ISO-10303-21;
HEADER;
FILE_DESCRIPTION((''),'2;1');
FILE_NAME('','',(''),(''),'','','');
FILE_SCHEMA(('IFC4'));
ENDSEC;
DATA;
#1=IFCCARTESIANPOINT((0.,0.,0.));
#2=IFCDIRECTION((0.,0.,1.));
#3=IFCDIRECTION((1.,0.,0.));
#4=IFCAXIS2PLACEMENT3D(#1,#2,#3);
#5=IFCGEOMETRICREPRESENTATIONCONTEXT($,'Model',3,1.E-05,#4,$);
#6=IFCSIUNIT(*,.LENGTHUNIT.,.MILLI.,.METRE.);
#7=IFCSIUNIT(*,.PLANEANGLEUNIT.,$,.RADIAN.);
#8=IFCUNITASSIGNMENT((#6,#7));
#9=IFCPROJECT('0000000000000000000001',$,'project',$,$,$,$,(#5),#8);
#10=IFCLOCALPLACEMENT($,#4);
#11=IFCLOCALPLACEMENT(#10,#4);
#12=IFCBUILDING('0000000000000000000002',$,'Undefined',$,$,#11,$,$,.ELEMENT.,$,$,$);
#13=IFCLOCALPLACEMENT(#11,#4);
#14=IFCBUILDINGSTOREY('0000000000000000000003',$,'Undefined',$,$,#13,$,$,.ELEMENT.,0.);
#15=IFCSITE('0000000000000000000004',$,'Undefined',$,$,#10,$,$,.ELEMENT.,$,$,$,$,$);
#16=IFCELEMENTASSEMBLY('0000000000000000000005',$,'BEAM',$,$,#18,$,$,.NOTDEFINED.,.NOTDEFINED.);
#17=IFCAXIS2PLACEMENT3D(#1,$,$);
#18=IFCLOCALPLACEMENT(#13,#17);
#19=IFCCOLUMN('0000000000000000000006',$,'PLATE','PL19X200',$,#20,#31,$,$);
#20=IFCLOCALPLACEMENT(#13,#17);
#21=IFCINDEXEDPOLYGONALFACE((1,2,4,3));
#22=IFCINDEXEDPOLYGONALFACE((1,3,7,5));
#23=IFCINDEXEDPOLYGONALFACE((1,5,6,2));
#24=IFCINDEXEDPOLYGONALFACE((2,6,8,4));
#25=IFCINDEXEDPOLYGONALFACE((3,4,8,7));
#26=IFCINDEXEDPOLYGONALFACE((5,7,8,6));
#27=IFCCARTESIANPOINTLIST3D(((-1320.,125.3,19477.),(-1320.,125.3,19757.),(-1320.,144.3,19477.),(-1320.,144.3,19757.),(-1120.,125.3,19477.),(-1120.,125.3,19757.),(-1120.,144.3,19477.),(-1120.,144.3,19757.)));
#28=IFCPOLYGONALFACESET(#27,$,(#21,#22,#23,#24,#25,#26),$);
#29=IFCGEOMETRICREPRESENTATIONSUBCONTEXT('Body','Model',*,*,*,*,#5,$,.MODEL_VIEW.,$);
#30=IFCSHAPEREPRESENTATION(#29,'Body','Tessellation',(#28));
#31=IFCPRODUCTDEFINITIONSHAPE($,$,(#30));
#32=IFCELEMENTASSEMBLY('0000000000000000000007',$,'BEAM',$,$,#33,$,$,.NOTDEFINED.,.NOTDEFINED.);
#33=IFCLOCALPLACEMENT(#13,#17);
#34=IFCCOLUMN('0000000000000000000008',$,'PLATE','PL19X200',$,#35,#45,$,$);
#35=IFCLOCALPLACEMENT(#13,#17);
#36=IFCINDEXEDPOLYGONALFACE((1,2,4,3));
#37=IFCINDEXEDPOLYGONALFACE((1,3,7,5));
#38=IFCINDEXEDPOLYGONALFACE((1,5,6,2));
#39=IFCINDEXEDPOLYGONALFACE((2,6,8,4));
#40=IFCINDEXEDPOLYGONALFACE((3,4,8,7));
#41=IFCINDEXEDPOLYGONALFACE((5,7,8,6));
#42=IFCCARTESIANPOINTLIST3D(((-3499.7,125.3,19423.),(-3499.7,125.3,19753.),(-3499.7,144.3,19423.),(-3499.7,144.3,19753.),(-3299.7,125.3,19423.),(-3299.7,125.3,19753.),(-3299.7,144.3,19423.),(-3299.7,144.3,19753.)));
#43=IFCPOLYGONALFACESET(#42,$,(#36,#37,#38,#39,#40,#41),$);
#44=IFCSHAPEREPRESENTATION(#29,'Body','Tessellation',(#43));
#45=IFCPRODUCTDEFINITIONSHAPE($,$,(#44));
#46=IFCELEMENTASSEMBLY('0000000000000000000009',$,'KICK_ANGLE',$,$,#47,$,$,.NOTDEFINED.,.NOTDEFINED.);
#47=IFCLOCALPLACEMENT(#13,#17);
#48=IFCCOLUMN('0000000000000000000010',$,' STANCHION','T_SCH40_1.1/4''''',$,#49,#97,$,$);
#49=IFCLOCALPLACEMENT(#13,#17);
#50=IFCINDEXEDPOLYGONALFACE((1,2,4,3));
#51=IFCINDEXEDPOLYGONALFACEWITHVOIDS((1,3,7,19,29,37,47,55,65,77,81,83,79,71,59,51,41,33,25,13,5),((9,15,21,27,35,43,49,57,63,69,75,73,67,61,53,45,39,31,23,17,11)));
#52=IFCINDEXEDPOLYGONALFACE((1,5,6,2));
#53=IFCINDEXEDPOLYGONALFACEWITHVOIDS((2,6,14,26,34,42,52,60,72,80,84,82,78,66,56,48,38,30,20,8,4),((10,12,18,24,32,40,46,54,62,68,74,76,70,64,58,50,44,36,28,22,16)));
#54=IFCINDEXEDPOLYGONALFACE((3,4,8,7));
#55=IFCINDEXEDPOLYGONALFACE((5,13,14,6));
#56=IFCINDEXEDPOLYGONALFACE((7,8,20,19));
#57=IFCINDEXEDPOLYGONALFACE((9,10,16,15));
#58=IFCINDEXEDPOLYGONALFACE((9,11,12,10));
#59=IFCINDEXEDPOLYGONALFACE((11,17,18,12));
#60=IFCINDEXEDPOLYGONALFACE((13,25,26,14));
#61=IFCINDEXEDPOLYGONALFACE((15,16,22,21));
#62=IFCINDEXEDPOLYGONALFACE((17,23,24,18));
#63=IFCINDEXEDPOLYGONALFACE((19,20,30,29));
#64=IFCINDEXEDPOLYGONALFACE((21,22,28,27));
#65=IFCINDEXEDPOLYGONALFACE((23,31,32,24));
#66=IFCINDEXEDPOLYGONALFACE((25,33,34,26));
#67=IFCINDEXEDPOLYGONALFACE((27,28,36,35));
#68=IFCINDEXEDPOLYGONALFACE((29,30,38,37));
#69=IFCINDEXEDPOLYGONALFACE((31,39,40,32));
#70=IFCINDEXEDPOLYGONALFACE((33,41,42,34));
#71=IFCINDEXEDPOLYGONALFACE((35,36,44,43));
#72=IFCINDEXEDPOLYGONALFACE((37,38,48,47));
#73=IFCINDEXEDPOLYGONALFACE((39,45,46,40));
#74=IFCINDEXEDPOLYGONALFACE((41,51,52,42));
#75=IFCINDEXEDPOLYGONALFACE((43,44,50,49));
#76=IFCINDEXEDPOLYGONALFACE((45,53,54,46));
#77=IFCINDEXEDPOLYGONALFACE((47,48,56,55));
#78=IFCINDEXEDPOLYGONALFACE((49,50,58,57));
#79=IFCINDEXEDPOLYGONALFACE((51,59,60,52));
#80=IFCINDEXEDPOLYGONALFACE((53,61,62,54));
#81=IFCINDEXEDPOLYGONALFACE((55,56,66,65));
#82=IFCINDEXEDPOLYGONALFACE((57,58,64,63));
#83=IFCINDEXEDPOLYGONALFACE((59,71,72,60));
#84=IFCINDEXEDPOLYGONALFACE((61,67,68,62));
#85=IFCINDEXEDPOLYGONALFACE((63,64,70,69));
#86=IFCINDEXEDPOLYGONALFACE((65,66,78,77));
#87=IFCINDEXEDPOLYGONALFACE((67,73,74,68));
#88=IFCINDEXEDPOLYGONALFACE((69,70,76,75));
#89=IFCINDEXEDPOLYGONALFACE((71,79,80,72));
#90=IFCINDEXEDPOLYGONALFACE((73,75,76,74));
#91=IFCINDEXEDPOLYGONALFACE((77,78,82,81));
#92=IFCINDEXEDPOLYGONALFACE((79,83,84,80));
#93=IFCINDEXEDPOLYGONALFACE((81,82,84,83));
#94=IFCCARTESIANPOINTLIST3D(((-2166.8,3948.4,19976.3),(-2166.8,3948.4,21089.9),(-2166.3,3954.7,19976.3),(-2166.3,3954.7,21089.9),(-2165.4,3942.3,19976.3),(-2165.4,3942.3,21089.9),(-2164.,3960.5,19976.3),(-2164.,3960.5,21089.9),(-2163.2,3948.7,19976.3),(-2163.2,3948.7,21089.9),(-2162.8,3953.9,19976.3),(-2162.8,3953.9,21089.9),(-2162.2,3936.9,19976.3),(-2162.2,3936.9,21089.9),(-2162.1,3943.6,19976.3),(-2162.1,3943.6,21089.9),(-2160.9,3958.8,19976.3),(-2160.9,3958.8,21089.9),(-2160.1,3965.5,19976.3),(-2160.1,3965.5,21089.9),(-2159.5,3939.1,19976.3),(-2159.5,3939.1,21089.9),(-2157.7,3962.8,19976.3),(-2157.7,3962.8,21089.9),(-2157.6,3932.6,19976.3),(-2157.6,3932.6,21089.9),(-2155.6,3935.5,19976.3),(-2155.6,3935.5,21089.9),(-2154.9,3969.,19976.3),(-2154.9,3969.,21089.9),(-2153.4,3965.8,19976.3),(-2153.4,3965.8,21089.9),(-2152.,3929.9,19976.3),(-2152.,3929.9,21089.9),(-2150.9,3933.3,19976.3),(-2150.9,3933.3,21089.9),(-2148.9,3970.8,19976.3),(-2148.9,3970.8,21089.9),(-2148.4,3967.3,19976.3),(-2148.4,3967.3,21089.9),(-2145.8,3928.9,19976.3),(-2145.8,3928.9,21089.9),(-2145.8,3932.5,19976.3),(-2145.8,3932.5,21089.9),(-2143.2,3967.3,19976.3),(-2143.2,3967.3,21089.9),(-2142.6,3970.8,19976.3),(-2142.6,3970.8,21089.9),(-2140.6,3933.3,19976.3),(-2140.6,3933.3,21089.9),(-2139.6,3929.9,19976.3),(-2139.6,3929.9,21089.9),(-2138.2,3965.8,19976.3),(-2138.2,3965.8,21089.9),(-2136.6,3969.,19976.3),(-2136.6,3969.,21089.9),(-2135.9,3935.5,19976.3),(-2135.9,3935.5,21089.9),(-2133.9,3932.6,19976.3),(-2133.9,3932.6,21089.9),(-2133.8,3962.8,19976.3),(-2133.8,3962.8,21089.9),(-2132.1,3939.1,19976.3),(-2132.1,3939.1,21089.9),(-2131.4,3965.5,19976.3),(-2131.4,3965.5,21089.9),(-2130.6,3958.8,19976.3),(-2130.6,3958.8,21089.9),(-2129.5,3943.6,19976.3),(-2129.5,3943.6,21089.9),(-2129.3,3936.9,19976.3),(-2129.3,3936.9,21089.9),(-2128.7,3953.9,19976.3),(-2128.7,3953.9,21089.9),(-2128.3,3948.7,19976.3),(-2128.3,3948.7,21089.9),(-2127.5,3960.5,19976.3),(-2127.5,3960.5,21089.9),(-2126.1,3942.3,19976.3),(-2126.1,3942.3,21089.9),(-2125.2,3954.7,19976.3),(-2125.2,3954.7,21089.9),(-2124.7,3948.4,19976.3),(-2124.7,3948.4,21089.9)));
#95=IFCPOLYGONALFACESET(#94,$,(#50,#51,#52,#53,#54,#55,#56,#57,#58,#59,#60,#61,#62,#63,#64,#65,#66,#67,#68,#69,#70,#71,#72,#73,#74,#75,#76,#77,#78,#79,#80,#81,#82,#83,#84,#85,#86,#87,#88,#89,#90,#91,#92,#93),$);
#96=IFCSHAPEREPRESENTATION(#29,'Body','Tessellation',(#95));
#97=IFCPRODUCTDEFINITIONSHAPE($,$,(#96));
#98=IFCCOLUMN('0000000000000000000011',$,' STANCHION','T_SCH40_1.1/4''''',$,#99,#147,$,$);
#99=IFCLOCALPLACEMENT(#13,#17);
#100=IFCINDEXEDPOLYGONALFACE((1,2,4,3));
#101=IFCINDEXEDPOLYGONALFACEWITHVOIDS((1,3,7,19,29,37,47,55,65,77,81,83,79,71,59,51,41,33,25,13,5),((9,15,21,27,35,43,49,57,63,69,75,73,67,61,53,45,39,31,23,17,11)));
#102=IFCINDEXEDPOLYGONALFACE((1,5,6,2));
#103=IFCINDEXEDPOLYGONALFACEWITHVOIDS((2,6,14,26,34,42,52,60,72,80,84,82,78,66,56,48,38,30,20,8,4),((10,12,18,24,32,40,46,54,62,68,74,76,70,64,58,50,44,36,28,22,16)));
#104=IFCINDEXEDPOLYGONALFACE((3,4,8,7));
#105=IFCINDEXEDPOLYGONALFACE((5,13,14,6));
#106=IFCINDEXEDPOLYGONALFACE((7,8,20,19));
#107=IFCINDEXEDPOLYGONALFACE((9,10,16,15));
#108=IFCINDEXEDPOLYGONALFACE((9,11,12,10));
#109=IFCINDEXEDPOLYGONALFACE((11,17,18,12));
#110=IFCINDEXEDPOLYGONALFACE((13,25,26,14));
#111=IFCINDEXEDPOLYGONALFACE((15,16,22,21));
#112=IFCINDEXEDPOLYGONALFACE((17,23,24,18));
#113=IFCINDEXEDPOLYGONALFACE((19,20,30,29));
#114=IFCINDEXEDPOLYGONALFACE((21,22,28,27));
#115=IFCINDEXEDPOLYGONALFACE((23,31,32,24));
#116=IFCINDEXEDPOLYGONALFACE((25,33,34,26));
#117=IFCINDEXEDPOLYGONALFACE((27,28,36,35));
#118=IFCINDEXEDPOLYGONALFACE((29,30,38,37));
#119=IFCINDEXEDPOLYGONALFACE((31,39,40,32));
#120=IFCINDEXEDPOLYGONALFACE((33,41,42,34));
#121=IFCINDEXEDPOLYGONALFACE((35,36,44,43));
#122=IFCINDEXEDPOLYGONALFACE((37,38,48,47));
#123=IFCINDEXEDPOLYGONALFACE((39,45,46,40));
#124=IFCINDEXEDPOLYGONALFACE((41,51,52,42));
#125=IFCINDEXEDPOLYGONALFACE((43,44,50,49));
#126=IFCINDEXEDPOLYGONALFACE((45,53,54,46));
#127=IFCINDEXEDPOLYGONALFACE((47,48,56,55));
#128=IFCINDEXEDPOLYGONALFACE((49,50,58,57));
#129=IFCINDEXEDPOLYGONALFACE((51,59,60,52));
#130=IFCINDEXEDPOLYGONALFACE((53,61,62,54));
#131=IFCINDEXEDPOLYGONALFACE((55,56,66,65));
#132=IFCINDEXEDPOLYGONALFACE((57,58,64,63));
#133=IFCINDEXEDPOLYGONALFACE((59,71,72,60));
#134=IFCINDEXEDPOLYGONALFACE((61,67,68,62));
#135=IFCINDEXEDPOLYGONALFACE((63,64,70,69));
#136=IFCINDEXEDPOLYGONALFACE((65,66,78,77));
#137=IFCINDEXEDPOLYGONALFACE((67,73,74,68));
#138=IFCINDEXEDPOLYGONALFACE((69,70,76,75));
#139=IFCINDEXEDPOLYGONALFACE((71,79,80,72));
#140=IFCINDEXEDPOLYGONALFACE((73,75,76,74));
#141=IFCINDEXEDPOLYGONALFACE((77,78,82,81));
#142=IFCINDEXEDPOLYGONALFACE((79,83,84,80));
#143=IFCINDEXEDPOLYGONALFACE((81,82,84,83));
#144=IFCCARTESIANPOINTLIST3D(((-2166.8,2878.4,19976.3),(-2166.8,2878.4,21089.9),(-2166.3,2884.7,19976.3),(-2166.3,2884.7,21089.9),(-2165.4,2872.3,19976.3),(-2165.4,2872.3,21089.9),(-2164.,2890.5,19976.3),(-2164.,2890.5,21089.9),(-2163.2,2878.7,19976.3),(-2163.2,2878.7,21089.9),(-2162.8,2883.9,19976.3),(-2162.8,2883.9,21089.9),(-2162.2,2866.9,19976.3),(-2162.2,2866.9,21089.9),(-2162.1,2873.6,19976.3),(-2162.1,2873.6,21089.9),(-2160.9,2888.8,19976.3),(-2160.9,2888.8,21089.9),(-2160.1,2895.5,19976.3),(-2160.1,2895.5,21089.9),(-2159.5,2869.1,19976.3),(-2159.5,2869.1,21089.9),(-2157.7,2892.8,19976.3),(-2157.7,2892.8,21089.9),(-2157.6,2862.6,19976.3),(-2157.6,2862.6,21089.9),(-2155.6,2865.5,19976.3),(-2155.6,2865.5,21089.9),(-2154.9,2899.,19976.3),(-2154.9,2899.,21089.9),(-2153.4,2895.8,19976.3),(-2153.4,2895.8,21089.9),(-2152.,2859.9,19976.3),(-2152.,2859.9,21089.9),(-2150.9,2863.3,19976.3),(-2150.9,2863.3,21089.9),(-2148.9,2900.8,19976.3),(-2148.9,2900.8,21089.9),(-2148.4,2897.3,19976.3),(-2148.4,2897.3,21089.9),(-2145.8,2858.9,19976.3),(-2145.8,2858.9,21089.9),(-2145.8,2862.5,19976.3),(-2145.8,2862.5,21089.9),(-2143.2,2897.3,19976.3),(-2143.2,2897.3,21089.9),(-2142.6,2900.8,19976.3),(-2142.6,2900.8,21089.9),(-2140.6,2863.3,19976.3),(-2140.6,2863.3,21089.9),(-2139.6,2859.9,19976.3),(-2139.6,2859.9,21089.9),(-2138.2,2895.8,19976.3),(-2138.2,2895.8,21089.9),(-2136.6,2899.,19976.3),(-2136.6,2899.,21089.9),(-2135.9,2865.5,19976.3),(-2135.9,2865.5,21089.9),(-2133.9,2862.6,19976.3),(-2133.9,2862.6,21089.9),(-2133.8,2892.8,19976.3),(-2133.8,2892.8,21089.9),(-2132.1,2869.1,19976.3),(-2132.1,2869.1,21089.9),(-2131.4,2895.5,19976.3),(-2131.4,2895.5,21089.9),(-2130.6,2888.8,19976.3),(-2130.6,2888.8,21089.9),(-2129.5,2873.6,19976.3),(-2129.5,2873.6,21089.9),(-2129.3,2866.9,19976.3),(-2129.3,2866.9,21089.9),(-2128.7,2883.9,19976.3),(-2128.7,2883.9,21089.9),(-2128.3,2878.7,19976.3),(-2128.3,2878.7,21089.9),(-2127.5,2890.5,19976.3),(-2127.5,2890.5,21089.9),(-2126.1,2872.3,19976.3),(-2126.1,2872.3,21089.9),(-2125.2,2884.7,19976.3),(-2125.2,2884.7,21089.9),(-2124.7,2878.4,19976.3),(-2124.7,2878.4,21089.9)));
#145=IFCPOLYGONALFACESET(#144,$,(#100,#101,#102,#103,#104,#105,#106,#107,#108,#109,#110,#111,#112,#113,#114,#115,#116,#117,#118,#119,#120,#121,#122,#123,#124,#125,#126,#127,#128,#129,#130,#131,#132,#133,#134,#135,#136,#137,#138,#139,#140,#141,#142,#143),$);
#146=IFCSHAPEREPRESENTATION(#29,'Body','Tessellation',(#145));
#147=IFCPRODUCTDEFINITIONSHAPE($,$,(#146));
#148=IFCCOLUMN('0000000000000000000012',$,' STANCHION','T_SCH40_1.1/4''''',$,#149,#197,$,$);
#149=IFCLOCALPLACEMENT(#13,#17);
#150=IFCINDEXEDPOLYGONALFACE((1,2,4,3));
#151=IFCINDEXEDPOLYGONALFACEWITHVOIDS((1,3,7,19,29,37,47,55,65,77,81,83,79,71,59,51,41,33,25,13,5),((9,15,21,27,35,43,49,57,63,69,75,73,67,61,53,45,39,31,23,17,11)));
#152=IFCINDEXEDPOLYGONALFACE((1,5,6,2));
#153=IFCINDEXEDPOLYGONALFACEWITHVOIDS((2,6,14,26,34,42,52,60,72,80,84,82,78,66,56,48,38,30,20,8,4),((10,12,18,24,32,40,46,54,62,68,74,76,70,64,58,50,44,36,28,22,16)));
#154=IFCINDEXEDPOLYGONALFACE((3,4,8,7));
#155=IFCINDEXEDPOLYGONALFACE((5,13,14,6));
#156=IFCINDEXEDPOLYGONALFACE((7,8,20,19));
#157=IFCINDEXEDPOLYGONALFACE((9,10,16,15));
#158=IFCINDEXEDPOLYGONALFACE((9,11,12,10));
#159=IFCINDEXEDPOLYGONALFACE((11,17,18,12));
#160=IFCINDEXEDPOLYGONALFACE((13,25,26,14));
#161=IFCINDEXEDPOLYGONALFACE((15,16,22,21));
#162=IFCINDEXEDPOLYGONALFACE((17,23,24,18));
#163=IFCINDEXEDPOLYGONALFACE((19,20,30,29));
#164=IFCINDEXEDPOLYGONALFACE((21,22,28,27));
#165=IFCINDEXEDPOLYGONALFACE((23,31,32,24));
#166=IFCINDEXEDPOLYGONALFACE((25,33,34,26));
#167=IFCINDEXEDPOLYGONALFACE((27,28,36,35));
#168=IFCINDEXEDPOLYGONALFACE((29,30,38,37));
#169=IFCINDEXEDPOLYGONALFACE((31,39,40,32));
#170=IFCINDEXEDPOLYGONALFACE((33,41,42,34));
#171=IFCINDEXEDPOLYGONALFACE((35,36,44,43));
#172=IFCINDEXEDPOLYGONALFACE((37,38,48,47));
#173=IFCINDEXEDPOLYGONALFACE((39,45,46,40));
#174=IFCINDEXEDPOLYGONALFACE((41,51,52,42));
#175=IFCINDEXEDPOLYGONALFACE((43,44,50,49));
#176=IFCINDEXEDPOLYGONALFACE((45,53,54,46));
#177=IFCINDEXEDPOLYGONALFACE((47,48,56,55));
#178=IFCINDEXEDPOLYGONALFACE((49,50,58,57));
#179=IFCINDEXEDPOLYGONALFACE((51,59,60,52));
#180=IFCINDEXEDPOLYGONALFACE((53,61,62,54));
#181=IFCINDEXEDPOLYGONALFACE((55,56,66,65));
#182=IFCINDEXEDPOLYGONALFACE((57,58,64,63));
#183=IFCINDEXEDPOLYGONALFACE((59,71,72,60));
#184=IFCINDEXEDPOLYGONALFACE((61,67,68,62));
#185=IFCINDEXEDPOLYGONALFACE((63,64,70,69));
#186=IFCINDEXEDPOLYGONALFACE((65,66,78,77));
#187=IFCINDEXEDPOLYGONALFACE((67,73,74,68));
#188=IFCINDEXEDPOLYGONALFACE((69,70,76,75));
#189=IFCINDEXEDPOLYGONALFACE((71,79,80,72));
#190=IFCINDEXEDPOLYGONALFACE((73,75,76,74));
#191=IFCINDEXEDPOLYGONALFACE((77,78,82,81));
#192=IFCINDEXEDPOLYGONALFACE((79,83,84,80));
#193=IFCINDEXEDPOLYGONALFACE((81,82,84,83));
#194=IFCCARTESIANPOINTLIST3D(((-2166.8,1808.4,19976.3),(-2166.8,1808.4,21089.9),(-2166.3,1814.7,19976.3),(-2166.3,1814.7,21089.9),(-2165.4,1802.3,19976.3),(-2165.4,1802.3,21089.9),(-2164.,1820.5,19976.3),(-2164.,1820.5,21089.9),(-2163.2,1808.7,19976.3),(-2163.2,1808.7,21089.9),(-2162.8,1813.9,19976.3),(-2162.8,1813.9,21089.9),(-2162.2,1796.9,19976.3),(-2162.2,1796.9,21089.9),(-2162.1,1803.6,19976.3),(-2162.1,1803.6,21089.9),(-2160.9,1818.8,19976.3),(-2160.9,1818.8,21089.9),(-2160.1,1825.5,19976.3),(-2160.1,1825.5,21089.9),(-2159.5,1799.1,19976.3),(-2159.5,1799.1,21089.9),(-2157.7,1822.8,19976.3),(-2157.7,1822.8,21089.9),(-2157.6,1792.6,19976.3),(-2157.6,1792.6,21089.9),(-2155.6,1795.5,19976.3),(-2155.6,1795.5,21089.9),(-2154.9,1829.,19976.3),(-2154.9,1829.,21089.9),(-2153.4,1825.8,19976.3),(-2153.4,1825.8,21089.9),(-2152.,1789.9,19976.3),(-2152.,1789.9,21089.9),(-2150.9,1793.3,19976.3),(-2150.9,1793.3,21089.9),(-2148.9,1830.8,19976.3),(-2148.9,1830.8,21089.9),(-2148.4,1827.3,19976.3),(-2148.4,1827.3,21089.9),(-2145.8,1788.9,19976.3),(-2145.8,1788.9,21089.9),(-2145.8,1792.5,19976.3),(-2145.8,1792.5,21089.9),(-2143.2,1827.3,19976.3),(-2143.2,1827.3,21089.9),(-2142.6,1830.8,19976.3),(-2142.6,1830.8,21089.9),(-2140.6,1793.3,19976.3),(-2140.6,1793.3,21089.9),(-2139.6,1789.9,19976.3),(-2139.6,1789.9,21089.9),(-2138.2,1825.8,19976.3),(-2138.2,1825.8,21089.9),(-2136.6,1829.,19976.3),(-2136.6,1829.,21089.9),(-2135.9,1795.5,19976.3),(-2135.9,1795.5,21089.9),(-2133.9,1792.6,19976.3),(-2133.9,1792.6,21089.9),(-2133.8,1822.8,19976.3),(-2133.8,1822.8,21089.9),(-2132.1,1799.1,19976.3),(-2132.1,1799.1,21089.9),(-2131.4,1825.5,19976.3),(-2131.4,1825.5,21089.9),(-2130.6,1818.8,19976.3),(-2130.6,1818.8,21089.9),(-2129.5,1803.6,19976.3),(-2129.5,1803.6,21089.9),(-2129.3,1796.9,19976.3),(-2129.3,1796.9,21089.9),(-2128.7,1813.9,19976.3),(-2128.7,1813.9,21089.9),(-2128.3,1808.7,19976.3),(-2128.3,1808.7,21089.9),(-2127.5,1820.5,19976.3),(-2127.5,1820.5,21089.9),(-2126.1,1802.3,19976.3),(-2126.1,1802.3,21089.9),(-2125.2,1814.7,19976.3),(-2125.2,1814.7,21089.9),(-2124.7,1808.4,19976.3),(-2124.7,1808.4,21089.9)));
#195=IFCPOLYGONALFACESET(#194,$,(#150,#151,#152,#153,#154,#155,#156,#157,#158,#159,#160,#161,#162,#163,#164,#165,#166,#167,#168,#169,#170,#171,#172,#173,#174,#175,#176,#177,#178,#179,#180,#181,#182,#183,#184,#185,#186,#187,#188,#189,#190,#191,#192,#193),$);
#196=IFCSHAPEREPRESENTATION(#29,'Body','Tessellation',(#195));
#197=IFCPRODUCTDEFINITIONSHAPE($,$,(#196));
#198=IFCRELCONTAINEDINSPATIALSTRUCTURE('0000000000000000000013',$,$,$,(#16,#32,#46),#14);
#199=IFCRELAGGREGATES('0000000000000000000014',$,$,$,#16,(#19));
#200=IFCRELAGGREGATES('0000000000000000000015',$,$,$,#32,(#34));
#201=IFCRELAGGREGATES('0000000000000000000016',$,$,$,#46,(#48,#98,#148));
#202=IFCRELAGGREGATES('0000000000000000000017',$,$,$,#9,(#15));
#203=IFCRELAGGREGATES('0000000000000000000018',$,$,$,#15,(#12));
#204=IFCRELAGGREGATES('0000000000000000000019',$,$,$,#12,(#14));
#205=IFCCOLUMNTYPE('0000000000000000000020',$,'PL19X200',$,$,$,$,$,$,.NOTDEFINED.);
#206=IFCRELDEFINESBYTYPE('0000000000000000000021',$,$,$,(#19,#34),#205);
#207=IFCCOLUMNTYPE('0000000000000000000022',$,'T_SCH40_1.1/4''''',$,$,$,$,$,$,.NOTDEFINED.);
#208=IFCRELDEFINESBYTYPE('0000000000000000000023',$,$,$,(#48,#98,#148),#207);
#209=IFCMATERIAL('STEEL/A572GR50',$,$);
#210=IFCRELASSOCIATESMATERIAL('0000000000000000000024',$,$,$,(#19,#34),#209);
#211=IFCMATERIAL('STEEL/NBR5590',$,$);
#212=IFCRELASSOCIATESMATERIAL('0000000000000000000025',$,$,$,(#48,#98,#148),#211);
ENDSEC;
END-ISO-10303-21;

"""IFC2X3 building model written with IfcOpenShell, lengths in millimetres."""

from ifc_helpers import new_model, si_unit, frame, origin_with_axes, origin_2d_with_axis, place, context, subcontext, project, spatial, rectangle, hollow_circle, extrude, material, type_object, element, aggregate, save


model = new_model("IFC2X3")

# Units and contexts
model_context = context("Model", 3, precision=1e-05, world=origin_with_axes())
body_context = subcontext(model_context, "Body", "Model", "MODEL_VIEW")
ifc_project = project(units=[si_unit("LENGTHUNIT", "METRE", prefix="MILLI"), si_unit("PLANEANGLEUNIT", "RADIAN")], contexts=[model_context])

# Site, building, storey
site_placement = place(None, origin_with_axes())
site = spatial("IfcSite", under=ifc_project, at=site_placement, Name="Undefined", CompositionType="ELEMENT")
building_placement = place(site_placement, origin_with_axes())
building = spatial("IfcBuilding", under=site, at=building_placement, Name="Undefined", CompositionType="ELEMENT")
storey_placement = place(building_placement, origin_with_axes())
storey = spatial("IfcBuildingStorey", under=building, at=storey_placement, Name="Undefined", CompositionType="ELEMENT", Elevation=0.0)

# Element assemblies, columns
assembly_1_placement = place(storey_placement, origin_with_axes())
assembly_1 = element("IfcElementAssembly", 1, at=assembly_1_placement, inside=storey, Name="BEAM", AssemblyPlace="NOTDEFINED", PredefinedType="NOTDEFINED")
ifc_material_1 = material(Name="STEEL/A572GR50")
column_type_1 = type_object("IfcColumnType", Name="PL19X200", PredefinedType="NOTDEFINED")
column_1_placement = place(assembly_1_placement, frame((-1220.0, 134.8, 19477.0), z_axis=(0.0, 0.0, 1.0), x_axis=(1.0, 0.0, 0.0)))
column_1 = element("IfcColumn", 2, at=column_1_placement, type_object=column_type_1, material=ifc_material_1, Name="PLATE", Description="PL19X200", context=body_context, shape_type="SweptSolid", body=[
    extrude(rectangle(XDim=19.0, YDim=200.0, at=origin_2d_with_axis()), frame((0.0, 0.0, 280.0), z_axis=(0.0, 0.0, -1.0), x_axis=(0.0, 1.0, 0.0)), (0.0, 0.0, 1.0), 280.0),
])
assembly_2_placement = place(storey_placement, origin_with_axes())
assembly_2 = element("IfcElementAssembly", 3, at=assembly_2_placement, inside=storey, Name="BEAM", AssemblyPlace="NOTDEFINED", PredefinedType="NOTDEFINED")
column_2_placement = place(assembly_2_placement, frame((-3399.7, 134.8, 19423.0), z_axis=(0.0, 0.0, 1.0), x_axis=(1.0, 0.0, 0.0)))
column_2 = element("IfcColumn", 4, at=column_2_placement, type_object=column_type_1, material=ifc_material_1, Name="PLATE", Description="PL19X200", context=body_context, shape_type="SweptSolid", body=[
    extrude(rectangle(XDim=19.0, YDim=200.0, at=origin_2d_with_axis()), frame((0.0, 0.0, 330.0), z_axis=(0.0, 0.0, -1.0), x_axis=(0.0, 1.0, 0.0)), (0.0, 0.0, 1.0), 330.0),
])

# Element assembly, columns
assembly_3_placement = place(storey_placement, origin_with_axes())
assembly_3 = element("IfcElementAssembly", 5, at=assembly_3_placement, inside=storey, Name="KICK_ANGLE", AssemblyPlace="NOTDEFINED", PredefinedType="NOTDEFINED")
ifc_material_2 = material(Name="STEEL/NBR5590")
column_type_2 = type_object("IfcColumnType", Name="T_SCH40_1.1/4''", PredefinedType="NOTDEFINED")
column_3_placement = place(assembly_3_placement, frame((-2145.8, 3950.0, 19976.3), z_axis=(0.0, 0.0, 1.0), x_axis=(-1.0, 0.0, 0.0)))
column_3 = element("IfcColumn", 6, at=column_3_placement, type_object=column_type_2, material=ifc_material_2, Name=" STANCHION", Description="T_SCH40_1.1/4''", context=body_context, shape_type="SweptSolid", body=[
    extrude(hollow_circle(Radius=21.1, WallThickness=3.6, at=origin_2d_with_axis()), frame((0.0, 0.0, 1113.6), z_axis=(0.0, 0.0, -1.0), x_axis=(0.0, 1.0, 0.0)), (0.0, 0.0, 1.0), 1113.6),
])
column_4_placement = place(assembly_3_placement, frame((-2145.8, 2880.0, 19976.3), z_axis=(0.0, 0.0, 1.0), x_axis=(-1.0, 0.0, 0.0)))
column_4 = element("IfcColumn", 7, at=column_4_placement, type_object=column_type_2, material=ifc_material_2, Name=" STANCHION", Description="T_SCH40_1.1/4''", context=body_context, shape_type="SweptSolid", body=[
    extrude(hollow_circle(Radius=21.1, WallThickness=3.6, at=origin_2d_with_axis()), frame((0.0, 0.0, 1113.6), z_axis=(0.0, 0.0, -1.0), x_axis=(0.0, 1.0, 0.0)), (0.0, 0.0, 1.0), 1113.6),
])
column_5_placement = place(assembly_3_placement, frame((-2145.8, 1810.0, 19976.3), z_axis=(0.0, 0.0, 1.0), x_axis=(-1.0, 0.0, 0.0)))
column_5 = element("IfcColumn", 8, at=column_5_placement, type_object=column_type_2, material=ifc_material_2, Name=" STANCHION", Description="T_SCH40_1.1/4''", context=body_context, shape_type="SweptSolid", body=[
    extrude(hollow_circle(Radius=21.1, WallThickness=3.6, at=origin_2d_with_axis()), frame((0.0, 0.0, 1113.6), z_axis=(0.0, 0.0, -1.0), x_axis=(0.0, 1.0, 0.0)), (0.0, 0.0, 1.0), 1113.6),
])

aggregate(assembly_1, [column_1])
aggregate(assembly_2, [column_2])
aggregate(assembly_3, [column_3, column_4, column_5])

save(model, "model.ifc")
